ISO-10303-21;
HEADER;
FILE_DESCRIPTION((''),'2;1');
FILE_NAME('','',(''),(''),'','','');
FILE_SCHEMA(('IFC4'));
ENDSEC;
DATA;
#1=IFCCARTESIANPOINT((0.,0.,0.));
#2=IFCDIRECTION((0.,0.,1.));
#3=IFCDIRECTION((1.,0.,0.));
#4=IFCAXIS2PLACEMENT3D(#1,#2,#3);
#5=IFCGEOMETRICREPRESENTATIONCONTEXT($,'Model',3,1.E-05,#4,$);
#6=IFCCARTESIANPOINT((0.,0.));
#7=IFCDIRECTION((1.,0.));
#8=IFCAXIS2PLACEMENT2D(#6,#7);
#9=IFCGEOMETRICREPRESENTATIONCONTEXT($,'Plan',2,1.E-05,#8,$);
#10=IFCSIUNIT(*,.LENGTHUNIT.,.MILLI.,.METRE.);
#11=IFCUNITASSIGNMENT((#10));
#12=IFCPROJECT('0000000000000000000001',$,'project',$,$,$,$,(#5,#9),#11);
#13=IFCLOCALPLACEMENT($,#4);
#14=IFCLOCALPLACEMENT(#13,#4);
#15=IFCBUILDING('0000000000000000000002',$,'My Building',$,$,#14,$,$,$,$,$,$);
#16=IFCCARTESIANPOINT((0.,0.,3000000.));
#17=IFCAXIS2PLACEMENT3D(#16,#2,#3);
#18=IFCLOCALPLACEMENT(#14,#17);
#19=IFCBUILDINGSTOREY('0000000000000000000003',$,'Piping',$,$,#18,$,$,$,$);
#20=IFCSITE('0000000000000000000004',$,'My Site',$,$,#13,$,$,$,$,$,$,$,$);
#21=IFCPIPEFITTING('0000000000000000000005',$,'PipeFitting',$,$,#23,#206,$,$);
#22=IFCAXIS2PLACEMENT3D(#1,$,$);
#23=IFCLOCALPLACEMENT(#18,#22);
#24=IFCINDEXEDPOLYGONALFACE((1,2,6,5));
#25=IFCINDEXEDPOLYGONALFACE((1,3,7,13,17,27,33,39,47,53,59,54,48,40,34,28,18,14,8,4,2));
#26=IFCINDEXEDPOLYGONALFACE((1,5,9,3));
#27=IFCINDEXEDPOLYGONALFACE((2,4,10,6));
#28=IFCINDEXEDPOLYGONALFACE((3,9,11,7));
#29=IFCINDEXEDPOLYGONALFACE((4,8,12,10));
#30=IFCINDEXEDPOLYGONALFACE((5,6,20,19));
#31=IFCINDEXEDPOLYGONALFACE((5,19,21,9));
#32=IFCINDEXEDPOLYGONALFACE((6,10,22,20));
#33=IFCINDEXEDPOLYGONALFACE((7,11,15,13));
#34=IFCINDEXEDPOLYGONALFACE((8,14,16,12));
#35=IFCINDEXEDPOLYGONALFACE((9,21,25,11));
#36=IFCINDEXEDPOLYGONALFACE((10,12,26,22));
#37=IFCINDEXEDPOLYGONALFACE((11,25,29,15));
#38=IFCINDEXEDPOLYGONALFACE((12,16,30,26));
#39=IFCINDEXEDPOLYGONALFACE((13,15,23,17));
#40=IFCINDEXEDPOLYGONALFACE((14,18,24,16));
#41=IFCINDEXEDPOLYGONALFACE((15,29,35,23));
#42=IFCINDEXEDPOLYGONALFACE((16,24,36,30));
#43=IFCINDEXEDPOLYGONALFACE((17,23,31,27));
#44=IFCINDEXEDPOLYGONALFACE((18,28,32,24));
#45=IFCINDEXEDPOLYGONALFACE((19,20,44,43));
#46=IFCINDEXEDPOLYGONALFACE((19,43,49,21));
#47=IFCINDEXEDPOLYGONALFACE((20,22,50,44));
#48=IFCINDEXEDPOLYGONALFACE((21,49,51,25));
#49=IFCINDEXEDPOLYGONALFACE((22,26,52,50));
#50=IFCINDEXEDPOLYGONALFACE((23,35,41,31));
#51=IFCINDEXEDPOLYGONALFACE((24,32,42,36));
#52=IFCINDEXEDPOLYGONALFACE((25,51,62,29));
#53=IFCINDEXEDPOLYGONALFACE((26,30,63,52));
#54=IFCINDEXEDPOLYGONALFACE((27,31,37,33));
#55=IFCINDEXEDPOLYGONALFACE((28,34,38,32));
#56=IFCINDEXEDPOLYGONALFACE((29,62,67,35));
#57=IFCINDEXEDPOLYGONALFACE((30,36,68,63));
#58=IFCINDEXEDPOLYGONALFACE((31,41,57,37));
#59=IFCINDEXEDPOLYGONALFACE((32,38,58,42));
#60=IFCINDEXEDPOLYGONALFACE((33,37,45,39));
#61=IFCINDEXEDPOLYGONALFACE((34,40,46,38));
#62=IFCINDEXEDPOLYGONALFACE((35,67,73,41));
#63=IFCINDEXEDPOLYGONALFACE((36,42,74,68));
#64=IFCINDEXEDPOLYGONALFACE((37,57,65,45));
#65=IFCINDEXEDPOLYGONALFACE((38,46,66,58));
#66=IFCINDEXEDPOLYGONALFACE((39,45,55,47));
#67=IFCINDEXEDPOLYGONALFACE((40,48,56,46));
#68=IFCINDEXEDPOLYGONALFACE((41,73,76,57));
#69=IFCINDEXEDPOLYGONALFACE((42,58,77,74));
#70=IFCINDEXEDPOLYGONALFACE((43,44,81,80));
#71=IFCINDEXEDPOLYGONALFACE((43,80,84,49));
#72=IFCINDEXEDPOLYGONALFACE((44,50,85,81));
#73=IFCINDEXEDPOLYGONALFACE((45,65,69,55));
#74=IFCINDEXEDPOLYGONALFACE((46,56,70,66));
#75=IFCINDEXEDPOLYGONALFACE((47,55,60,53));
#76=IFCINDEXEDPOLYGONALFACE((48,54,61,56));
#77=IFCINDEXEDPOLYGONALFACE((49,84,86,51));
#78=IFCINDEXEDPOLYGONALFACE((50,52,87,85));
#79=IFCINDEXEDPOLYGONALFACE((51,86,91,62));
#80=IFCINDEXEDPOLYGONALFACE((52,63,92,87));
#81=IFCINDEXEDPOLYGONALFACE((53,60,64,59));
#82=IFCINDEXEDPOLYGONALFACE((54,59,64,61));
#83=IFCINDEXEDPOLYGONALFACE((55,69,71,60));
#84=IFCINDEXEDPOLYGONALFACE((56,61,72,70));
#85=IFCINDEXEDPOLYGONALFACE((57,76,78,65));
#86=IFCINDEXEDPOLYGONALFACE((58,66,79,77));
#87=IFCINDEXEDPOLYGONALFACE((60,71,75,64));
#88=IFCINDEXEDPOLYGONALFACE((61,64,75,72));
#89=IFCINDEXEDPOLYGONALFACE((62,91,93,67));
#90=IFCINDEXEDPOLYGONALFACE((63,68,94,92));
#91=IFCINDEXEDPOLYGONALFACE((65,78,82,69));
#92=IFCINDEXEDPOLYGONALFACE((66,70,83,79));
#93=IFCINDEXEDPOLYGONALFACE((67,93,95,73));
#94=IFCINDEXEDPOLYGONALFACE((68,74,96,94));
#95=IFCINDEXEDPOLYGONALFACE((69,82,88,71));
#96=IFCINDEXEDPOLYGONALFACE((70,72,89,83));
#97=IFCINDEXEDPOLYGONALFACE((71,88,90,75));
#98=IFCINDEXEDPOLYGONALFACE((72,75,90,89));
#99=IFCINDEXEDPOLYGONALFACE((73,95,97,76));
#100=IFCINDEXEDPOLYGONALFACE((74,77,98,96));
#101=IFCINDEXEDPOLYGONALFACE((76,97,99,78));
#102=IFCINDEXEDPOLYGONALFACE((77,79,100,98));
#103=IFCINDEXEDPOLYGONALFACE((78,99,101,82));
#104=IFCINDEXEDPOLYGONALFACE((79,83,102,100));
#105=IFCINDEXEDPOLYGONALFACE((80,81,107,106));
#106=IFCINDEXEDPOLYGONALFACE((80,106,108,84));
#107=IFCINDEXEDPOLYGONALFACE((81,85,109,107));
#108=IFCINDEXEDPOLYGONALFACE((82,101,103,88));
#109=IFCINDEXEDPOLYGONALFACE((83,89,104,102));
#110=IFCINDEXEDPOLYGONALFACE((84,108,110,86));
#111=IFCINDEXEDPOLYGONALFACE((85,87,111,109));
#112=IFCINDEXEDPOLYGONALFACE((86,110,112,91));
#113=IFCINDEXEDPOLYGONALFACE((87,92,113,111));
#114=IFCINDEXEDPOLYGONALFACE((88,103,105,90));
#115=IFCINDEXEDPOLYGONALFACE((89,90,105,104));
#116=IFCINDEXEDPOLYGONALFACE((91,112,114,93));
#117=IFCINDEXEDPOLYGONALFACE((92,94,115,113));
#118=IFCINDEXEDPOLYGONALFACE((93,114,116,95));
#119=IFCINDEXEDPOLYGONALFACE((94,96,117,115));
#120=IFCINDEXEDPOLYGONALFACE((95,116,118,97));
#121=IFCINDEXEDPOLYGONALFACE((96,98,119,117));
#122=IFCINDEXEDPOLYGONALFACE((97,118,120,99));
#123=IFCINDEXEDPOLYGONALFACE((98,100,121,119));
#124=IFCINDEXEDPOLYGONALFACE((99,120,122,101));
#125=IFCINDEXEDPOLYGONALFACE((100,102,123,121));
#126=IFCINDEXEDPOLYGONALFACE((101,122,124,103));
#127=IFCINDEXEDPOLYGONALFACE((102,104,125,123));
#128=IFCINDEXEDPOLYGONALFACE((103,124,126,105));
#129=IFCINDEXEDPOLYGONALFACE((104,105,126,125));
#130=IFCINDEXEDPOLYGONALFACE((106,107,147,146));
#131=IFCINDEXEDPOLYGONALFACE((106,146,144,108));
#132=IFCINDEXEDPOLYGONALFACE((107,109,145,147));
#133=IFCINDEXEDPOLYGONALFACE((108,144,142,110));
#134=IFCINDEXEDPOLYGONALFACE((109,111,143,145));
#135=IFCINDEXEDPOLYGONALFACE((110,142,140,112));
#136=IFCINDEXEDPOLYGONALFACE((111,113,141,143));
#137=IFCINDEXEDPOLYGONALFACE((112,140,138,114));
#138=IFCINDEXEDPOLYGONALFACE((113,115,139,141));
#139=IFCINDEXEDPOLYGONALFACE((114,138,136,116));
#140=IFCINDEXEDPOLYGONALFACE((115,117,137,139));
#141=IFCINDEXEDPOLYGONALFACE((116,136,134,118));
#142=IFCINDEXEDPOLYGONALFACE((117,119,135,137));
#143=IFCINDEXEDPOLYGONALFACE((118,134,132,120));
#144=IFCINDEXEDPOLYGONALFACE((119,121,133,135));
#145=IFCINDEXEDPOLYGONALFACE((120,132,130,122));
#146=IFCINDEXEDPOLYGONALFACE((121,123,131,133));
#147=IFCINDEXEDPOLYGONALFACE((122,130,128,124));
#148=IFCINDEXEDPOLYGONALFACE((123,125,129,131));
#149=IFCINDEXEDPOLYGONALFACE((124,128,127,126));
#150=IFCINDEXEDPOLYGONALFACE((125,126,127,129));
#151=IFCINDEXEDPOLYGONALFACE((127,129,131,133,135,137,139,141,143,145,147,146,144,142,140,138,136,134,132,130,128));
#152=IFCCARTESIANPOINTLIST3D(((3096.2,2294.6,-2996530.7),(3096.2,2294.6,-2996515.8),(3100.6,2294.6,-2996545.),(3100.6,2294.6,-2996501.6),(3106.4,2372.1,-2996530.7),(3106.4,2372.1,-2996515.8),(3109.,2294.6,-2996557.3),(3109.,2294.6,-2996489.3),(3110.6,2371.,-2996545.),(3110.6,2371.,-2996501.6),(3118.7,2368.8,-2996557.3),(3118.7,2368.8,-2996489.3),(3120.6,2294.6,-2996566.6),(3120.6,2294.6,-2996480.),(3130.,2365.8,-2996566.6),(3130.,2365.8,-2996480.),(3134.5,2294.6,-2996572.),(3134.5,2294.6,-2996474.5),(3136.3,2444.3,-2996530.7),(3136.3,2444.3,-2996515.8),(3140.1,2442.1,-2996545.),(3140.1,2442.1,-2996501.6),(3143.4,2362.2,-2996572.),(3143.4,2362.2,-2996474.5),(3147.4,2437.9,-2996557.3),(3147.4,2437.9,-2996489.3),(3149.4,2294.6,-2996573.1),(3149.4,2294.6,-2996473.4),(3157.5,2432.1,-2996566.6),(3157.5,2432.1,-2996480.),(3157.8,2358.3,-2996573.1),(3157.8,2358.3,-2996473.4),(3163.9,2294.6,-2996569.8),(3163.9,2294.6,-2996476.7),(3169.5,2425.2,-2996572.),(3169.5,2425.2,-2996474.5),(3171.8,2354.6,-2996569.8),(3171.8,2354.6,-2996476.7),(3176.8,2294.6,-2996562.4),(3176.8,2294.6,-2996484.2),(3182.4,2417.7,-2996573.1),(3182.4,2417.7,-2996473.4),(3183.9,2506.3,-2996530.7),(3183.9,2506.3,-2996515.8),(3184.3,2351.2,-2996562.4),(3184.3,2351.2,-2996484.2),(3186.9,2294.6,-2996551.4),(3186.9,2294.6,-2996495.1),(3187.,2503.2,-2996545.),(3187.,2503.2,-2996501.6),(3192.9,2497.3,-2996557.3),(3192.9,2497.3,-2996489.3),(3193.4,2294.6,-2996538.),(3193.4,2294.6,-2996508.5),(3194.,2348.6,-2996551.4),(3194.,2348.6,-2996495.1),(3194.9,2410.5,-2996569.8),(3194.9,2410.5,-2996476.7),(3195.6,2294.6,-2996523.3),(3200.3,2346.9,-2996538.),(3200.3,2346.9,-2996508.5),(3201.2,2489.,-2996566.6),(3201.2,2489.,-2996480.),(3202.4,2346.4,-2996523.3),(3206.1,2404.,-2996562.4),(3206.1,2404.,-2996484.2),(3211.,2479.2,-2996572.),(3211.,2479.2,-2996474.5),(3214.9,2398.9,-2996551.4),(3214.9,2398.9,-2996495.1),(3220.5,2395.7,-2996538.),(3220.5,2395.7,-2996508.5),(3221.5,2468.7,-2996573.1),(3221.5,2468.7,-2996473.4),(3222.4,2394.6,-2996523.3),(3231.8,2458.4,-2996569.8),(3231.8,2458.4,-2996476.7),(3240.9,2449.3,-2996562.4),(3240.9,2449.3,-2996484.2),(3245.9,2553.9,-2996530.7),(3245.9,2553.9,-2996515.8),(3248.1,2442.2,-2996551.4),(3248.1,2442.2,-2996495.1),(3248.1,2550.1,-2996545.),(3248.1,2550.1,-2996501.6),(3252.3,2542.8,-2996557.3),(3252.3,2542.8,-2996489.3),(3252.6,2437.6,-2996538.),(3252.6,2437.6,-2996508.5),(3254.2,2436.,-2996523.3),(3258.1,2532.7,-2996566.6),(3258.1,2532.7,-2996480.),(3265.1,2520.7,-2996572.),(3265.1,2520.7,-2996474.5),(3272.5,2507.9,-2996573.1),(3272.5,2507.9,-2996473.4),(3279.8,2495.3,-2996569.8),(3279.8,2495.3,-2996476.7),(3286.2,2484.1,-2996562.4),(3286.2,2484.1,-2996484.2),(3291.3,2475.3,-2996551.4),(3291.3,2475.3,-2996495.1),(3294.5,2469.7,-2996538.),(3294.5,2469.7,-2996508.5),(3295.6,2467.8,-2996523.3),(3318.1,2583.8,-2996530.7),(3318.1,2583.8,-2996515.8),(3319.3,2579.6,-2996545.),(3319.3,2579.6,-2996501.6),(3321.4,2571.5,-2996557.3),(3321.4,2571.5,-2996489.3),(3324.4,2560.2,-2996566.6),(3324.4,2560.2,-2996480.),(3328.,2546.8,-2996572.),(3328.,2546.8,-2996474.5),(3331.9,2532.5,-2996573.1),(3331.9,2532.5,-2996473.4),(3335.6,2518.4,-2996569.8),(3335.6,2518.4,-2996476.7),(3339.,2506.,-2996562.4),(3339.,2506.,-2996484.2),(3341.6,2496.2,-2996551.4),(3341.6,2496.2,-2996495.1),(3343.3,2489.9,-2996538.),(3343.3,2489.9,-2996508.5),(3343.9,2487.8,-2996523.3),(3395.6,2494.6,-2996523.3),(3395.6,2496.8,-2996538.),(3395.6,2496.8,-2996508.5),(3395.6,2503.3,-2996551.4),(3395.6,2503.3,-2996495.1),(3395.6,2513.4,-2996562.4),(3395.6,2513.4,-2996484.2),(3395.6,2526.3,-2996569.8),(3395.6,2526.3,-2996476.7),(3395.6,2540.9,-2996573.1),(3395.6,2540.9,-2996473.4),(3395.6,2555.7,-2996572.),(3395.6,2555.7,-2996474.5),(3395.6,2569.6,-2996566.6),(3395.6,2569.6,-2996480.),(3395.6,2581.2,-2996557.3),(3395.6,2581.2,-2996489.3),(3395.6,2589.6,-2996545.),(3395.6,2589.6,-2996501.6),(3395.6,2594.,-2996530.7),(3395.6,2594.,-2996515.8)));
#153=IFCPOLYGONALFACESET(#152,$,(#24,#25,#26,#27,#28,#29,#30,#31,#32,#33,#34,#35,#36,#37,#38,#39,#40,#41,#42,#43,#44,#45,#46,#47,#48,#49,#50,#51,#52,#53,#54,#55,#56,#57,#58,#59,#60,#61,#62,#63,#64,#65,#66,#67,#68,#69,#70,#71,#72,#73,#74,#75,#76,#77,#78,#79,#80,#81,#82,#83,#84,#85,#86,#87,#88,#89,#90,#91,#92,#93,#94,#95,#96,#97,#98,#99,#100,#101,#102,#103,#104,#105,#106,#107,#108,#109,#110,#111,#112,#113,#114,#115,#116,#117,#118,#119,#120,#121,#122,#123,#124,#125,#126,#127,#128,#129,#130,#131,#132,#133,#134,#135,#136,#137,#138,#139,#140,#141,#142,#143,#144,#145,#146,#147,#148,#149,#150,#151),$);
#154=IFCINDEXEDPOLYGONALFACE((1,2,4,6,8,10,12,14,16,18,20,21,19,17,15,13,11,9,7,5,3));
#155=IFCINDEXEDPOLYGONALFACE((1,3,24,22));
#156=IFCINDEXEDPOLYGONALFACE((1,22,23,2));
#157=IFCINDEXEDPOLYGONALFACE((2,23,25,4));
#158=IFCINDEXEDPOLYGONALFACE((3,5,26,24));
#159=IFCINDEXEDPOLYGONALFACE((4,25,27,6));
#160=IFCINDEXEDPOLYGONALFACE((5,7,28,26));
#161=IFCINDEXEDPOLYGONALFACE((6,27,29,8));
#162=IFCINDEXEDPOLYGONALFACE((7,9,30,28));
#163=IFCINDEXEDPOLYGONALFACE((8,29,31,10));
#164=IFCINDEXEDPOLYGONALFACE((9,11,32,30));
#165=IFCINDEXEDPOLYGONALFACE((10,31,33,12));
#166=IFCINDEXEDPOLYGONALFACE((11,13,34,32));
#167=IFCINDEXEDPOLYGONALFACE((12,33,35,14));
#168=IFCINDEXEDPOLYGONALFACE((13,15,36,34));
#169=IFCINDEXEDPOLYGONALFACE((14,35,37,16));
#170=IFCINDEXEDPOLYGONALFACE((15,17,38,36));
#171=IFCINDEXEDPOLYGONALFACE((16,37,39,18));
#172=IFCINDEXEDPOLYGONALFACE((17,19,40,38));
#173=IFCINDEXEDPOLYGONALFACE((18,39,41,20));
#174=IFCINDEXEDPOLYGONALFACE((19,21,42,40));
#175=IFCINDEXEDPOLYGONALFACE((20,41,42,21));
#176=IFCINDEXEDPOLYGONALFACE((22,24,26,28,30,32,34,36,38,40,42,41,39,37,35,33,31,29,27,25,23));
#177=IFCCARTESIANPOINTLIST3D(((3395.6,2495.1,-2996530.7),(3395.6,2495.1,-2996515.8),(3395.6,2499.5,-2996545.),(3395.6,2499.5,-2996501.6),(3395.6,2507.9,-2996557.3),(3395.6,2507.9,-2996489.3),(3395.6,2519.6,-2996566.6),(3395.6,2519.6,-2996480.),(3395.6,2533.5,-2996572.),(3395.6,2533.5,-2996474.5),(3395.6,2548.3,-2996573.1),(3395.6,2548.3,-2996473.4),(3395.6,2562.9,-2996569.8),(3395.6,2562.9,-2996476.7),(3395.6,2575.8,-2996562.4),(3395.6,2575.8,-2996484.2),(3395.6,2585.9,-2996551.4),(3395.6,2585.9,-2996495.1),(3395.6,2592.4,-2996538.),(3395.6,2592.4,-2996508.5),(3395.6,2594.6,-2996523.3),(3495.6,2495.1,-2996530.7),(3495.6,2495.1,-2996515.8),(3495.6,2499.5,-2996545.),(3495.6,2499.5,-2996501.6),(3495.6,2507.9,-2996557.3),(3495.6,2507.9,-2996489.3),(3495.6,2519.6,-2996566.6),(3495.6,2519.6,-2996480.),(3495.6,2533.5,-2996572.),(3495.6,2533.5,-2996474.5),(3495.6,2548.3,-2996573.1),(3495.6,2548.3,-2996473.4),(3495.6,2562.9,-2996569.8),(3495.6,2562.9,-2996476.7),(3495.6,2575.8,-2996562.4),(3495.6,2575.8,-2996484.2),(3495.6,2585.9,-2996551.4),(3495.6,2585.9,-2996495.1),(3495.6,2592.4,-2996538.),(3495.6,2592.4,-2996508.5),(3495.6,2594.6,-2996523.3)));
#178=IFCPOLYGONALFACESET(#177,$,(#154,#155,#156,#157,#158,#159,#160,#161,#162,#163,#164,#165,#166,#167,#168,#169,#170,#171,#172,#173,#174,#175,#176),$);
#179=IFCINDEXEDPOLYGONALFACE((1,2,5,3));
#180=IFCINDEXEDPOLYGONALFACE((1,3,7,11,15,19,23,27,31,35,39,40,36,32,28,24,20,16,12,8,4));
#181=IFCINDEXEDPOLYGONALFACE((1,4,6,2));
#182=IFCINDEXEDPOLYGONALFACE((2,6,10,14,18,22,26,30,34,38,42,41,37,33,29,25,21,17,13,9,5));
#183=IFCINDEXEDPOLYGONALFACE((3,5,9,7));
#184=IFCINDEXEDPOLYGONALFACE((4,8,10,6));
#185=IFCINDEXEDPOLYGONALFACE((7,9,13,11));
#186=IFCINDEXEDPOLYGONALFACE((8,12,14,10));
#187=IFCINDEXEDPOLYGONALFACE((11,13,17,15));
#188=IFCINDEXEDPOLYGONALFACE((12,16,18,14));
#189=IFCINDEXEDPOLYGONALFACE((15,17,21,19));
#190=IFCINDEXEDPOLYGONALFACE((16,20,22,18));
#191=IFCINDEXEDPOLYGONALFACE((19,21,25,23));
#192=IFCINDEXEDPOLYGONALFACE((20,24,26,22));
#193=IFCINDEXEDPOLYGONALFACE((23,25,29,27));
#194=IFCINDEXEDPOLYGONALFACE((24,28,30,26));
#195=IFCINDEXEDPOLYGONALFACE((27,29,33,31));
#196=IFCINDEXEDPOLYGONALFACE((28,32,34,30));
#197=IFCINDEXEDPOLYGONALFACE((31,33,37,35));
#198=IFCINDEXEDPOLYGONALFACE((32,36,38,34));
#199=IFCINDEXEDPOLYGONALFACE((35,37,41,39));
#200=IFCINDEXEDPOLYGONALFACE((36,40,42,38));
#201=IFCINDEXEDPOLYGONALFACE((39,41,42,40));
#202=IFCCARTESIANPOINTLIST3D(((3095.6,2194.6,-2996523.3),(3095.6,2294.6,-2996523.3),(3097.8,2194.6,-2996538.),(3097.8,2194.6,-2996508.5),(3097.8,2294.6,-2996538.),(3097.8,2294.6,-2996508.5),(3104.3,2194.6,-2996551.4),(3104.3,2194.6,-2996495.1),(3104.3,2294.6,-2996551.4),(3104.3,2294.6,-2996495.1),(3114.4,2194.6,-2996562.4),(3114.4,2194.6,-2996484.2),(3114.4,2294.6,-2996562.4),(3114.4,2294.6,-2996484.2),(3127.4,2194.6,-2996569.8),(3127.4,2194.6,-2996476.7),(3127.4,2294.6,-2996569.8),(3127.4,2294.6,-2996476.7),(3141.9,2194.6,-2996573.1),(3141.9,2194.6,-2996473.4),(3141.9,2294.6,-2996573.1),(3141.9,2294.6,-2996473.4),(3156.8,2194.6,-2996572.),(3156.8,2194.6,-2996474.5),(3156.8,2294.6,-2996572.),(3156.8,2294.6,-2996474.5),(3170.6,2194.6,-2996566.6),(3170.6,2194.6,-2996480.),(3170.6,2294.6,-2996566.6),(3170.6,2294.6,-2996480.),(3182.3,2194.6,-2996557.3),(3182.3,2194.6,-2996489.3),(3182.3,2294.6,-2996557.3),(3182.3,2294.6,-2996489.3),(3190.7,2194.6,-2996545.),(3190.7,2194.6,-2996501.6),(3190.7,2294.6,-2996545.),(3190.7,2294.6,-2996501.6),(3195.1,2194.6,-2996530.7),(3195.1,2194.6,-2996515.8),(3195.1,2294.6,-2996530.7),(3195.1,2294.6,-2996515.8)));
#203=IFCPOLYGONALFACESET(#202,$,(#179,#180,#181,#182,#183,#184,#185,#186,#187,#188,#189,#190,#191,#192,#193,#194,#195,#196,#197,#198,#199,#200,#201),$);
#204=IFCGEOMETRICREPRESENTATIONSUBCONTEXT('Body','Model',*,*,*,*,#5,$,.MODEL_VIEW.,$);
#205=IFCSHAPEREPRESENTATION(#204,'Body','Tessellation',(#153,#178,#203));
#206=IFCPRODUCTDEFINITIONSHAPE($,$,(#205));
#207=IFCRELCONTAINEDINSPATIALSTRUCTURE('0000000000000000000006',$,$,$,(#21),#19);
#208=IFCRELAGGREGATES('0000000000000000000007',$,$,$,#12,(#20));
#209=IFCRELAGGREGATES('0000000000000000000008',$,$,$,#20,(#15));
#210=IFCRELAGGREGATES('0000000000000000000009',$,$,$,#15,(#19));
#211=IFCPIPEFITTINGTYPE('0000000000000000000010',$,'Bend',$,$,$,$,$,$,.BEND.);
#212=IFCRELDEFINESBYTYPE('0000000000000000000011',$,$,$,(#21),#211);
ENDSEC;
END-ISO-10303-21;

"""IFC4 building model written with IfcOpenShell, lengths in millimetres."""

from ifc_helpers import new_model, entity, si_unit, frame, origin_with_axes, origin_2d_with_axis, place, context, subcontext, project, spatial, circle, extrude, source, transform, mapped, type_object, type_shapes, element, save


model = new_model("IFC4")

# Units and contexts
model_context = context("Model", 3, precision=1e-05, world=origin_with_axes())
plan_context = context("Plan", 2, precision=1e-05, world=origin_2d_with_axis())
body_context = subcontext(model_context, "Body", "Model", "MODEL_VIEW")
ifc_project = project(units=[si_unit("LENGTHUNIT", "METRE", prefix="MILLI")], contexts=[model_context, plan_context])

# Site, building, storey
site_placement = place(None, origin_with_axes())
site = spatial("IfcSite", under=ifc_project, at=site_placement, Name="My Site")
building_placement = place(site_placement, origin_with_axes())
building = spatial("IfcBuilding", under=site, at=building_placement, Name="My Building")
storey_placement = place(building_placement, frame((0.0, 0.0, 3000000.0), z_axis=(0.0, 0.0, 1.0), x_axis=(1.0, 0.0, 0.0)))
storey = spatial("IfcBuildingStorey", under=building, at=storey_placement, Name="Piping")

# Shared definitions
pipe_fitting_type_1 = type_object("IfcPipeFittingType", Name="Bend", PredefinedType="BEND")
shared_shape_1 = source(origin_with_axes(), body_context, "Body", "SolidModel", [
    entity("IfcSweptDiskSolid", entity("IfcIndexedPolyCurve", entity("IfcCartesianPointList3D", [[0.0, 0.0, -100.0], [-73.2, 0.0, -276.8], [-250.0, 0.0, -350.0]]), [entity("IfcArcIndex", [1, 2, 3])]), 50.0),
    extrude(circle(Radius=50.0), origin_with_axes(), (0.0, 0.0, -1.0), 100.0),
    extrude(circle(Radius=50.0), frame((-250.0, 0.0, -350.0), z_axis=(-1.0, 0.0, 0.0), x_axis=(0.0, 0.0, -1.0)), (0.0, 0.0, 1.0), 100.0),
])
type_shapes(pipe_fitting_type_1, [shared_shape_1])

# Pipe fitting
for number, where, z_axis, x_axis, name in (
    (1, (3495.6, 2544.6, -2996523.3), (1.0, 0.0, 0.0), (0.0, 1.0, 0.0), "PipeFitting"),
):
    element("IfcPipeFitting", number, at=place(storey_placement, frame(where, z_axis=z_axis, x_axis=x_axis)), inside=storey, type_object=pipe_fitting_type_1, Name=name, context=body_context, shape_type="MappedRepresentation", body=[
        mapped(shared_shape_1, transform((0.0, 0.0, 0.0), x_axis=(1.0, 0.0, 0.0), y_axis=(0.0, 1.0, 0.0), z_axis=(0.0, 0.0, 1.0), scale=1.0)),
    ])

save(model, "model.ifc")
